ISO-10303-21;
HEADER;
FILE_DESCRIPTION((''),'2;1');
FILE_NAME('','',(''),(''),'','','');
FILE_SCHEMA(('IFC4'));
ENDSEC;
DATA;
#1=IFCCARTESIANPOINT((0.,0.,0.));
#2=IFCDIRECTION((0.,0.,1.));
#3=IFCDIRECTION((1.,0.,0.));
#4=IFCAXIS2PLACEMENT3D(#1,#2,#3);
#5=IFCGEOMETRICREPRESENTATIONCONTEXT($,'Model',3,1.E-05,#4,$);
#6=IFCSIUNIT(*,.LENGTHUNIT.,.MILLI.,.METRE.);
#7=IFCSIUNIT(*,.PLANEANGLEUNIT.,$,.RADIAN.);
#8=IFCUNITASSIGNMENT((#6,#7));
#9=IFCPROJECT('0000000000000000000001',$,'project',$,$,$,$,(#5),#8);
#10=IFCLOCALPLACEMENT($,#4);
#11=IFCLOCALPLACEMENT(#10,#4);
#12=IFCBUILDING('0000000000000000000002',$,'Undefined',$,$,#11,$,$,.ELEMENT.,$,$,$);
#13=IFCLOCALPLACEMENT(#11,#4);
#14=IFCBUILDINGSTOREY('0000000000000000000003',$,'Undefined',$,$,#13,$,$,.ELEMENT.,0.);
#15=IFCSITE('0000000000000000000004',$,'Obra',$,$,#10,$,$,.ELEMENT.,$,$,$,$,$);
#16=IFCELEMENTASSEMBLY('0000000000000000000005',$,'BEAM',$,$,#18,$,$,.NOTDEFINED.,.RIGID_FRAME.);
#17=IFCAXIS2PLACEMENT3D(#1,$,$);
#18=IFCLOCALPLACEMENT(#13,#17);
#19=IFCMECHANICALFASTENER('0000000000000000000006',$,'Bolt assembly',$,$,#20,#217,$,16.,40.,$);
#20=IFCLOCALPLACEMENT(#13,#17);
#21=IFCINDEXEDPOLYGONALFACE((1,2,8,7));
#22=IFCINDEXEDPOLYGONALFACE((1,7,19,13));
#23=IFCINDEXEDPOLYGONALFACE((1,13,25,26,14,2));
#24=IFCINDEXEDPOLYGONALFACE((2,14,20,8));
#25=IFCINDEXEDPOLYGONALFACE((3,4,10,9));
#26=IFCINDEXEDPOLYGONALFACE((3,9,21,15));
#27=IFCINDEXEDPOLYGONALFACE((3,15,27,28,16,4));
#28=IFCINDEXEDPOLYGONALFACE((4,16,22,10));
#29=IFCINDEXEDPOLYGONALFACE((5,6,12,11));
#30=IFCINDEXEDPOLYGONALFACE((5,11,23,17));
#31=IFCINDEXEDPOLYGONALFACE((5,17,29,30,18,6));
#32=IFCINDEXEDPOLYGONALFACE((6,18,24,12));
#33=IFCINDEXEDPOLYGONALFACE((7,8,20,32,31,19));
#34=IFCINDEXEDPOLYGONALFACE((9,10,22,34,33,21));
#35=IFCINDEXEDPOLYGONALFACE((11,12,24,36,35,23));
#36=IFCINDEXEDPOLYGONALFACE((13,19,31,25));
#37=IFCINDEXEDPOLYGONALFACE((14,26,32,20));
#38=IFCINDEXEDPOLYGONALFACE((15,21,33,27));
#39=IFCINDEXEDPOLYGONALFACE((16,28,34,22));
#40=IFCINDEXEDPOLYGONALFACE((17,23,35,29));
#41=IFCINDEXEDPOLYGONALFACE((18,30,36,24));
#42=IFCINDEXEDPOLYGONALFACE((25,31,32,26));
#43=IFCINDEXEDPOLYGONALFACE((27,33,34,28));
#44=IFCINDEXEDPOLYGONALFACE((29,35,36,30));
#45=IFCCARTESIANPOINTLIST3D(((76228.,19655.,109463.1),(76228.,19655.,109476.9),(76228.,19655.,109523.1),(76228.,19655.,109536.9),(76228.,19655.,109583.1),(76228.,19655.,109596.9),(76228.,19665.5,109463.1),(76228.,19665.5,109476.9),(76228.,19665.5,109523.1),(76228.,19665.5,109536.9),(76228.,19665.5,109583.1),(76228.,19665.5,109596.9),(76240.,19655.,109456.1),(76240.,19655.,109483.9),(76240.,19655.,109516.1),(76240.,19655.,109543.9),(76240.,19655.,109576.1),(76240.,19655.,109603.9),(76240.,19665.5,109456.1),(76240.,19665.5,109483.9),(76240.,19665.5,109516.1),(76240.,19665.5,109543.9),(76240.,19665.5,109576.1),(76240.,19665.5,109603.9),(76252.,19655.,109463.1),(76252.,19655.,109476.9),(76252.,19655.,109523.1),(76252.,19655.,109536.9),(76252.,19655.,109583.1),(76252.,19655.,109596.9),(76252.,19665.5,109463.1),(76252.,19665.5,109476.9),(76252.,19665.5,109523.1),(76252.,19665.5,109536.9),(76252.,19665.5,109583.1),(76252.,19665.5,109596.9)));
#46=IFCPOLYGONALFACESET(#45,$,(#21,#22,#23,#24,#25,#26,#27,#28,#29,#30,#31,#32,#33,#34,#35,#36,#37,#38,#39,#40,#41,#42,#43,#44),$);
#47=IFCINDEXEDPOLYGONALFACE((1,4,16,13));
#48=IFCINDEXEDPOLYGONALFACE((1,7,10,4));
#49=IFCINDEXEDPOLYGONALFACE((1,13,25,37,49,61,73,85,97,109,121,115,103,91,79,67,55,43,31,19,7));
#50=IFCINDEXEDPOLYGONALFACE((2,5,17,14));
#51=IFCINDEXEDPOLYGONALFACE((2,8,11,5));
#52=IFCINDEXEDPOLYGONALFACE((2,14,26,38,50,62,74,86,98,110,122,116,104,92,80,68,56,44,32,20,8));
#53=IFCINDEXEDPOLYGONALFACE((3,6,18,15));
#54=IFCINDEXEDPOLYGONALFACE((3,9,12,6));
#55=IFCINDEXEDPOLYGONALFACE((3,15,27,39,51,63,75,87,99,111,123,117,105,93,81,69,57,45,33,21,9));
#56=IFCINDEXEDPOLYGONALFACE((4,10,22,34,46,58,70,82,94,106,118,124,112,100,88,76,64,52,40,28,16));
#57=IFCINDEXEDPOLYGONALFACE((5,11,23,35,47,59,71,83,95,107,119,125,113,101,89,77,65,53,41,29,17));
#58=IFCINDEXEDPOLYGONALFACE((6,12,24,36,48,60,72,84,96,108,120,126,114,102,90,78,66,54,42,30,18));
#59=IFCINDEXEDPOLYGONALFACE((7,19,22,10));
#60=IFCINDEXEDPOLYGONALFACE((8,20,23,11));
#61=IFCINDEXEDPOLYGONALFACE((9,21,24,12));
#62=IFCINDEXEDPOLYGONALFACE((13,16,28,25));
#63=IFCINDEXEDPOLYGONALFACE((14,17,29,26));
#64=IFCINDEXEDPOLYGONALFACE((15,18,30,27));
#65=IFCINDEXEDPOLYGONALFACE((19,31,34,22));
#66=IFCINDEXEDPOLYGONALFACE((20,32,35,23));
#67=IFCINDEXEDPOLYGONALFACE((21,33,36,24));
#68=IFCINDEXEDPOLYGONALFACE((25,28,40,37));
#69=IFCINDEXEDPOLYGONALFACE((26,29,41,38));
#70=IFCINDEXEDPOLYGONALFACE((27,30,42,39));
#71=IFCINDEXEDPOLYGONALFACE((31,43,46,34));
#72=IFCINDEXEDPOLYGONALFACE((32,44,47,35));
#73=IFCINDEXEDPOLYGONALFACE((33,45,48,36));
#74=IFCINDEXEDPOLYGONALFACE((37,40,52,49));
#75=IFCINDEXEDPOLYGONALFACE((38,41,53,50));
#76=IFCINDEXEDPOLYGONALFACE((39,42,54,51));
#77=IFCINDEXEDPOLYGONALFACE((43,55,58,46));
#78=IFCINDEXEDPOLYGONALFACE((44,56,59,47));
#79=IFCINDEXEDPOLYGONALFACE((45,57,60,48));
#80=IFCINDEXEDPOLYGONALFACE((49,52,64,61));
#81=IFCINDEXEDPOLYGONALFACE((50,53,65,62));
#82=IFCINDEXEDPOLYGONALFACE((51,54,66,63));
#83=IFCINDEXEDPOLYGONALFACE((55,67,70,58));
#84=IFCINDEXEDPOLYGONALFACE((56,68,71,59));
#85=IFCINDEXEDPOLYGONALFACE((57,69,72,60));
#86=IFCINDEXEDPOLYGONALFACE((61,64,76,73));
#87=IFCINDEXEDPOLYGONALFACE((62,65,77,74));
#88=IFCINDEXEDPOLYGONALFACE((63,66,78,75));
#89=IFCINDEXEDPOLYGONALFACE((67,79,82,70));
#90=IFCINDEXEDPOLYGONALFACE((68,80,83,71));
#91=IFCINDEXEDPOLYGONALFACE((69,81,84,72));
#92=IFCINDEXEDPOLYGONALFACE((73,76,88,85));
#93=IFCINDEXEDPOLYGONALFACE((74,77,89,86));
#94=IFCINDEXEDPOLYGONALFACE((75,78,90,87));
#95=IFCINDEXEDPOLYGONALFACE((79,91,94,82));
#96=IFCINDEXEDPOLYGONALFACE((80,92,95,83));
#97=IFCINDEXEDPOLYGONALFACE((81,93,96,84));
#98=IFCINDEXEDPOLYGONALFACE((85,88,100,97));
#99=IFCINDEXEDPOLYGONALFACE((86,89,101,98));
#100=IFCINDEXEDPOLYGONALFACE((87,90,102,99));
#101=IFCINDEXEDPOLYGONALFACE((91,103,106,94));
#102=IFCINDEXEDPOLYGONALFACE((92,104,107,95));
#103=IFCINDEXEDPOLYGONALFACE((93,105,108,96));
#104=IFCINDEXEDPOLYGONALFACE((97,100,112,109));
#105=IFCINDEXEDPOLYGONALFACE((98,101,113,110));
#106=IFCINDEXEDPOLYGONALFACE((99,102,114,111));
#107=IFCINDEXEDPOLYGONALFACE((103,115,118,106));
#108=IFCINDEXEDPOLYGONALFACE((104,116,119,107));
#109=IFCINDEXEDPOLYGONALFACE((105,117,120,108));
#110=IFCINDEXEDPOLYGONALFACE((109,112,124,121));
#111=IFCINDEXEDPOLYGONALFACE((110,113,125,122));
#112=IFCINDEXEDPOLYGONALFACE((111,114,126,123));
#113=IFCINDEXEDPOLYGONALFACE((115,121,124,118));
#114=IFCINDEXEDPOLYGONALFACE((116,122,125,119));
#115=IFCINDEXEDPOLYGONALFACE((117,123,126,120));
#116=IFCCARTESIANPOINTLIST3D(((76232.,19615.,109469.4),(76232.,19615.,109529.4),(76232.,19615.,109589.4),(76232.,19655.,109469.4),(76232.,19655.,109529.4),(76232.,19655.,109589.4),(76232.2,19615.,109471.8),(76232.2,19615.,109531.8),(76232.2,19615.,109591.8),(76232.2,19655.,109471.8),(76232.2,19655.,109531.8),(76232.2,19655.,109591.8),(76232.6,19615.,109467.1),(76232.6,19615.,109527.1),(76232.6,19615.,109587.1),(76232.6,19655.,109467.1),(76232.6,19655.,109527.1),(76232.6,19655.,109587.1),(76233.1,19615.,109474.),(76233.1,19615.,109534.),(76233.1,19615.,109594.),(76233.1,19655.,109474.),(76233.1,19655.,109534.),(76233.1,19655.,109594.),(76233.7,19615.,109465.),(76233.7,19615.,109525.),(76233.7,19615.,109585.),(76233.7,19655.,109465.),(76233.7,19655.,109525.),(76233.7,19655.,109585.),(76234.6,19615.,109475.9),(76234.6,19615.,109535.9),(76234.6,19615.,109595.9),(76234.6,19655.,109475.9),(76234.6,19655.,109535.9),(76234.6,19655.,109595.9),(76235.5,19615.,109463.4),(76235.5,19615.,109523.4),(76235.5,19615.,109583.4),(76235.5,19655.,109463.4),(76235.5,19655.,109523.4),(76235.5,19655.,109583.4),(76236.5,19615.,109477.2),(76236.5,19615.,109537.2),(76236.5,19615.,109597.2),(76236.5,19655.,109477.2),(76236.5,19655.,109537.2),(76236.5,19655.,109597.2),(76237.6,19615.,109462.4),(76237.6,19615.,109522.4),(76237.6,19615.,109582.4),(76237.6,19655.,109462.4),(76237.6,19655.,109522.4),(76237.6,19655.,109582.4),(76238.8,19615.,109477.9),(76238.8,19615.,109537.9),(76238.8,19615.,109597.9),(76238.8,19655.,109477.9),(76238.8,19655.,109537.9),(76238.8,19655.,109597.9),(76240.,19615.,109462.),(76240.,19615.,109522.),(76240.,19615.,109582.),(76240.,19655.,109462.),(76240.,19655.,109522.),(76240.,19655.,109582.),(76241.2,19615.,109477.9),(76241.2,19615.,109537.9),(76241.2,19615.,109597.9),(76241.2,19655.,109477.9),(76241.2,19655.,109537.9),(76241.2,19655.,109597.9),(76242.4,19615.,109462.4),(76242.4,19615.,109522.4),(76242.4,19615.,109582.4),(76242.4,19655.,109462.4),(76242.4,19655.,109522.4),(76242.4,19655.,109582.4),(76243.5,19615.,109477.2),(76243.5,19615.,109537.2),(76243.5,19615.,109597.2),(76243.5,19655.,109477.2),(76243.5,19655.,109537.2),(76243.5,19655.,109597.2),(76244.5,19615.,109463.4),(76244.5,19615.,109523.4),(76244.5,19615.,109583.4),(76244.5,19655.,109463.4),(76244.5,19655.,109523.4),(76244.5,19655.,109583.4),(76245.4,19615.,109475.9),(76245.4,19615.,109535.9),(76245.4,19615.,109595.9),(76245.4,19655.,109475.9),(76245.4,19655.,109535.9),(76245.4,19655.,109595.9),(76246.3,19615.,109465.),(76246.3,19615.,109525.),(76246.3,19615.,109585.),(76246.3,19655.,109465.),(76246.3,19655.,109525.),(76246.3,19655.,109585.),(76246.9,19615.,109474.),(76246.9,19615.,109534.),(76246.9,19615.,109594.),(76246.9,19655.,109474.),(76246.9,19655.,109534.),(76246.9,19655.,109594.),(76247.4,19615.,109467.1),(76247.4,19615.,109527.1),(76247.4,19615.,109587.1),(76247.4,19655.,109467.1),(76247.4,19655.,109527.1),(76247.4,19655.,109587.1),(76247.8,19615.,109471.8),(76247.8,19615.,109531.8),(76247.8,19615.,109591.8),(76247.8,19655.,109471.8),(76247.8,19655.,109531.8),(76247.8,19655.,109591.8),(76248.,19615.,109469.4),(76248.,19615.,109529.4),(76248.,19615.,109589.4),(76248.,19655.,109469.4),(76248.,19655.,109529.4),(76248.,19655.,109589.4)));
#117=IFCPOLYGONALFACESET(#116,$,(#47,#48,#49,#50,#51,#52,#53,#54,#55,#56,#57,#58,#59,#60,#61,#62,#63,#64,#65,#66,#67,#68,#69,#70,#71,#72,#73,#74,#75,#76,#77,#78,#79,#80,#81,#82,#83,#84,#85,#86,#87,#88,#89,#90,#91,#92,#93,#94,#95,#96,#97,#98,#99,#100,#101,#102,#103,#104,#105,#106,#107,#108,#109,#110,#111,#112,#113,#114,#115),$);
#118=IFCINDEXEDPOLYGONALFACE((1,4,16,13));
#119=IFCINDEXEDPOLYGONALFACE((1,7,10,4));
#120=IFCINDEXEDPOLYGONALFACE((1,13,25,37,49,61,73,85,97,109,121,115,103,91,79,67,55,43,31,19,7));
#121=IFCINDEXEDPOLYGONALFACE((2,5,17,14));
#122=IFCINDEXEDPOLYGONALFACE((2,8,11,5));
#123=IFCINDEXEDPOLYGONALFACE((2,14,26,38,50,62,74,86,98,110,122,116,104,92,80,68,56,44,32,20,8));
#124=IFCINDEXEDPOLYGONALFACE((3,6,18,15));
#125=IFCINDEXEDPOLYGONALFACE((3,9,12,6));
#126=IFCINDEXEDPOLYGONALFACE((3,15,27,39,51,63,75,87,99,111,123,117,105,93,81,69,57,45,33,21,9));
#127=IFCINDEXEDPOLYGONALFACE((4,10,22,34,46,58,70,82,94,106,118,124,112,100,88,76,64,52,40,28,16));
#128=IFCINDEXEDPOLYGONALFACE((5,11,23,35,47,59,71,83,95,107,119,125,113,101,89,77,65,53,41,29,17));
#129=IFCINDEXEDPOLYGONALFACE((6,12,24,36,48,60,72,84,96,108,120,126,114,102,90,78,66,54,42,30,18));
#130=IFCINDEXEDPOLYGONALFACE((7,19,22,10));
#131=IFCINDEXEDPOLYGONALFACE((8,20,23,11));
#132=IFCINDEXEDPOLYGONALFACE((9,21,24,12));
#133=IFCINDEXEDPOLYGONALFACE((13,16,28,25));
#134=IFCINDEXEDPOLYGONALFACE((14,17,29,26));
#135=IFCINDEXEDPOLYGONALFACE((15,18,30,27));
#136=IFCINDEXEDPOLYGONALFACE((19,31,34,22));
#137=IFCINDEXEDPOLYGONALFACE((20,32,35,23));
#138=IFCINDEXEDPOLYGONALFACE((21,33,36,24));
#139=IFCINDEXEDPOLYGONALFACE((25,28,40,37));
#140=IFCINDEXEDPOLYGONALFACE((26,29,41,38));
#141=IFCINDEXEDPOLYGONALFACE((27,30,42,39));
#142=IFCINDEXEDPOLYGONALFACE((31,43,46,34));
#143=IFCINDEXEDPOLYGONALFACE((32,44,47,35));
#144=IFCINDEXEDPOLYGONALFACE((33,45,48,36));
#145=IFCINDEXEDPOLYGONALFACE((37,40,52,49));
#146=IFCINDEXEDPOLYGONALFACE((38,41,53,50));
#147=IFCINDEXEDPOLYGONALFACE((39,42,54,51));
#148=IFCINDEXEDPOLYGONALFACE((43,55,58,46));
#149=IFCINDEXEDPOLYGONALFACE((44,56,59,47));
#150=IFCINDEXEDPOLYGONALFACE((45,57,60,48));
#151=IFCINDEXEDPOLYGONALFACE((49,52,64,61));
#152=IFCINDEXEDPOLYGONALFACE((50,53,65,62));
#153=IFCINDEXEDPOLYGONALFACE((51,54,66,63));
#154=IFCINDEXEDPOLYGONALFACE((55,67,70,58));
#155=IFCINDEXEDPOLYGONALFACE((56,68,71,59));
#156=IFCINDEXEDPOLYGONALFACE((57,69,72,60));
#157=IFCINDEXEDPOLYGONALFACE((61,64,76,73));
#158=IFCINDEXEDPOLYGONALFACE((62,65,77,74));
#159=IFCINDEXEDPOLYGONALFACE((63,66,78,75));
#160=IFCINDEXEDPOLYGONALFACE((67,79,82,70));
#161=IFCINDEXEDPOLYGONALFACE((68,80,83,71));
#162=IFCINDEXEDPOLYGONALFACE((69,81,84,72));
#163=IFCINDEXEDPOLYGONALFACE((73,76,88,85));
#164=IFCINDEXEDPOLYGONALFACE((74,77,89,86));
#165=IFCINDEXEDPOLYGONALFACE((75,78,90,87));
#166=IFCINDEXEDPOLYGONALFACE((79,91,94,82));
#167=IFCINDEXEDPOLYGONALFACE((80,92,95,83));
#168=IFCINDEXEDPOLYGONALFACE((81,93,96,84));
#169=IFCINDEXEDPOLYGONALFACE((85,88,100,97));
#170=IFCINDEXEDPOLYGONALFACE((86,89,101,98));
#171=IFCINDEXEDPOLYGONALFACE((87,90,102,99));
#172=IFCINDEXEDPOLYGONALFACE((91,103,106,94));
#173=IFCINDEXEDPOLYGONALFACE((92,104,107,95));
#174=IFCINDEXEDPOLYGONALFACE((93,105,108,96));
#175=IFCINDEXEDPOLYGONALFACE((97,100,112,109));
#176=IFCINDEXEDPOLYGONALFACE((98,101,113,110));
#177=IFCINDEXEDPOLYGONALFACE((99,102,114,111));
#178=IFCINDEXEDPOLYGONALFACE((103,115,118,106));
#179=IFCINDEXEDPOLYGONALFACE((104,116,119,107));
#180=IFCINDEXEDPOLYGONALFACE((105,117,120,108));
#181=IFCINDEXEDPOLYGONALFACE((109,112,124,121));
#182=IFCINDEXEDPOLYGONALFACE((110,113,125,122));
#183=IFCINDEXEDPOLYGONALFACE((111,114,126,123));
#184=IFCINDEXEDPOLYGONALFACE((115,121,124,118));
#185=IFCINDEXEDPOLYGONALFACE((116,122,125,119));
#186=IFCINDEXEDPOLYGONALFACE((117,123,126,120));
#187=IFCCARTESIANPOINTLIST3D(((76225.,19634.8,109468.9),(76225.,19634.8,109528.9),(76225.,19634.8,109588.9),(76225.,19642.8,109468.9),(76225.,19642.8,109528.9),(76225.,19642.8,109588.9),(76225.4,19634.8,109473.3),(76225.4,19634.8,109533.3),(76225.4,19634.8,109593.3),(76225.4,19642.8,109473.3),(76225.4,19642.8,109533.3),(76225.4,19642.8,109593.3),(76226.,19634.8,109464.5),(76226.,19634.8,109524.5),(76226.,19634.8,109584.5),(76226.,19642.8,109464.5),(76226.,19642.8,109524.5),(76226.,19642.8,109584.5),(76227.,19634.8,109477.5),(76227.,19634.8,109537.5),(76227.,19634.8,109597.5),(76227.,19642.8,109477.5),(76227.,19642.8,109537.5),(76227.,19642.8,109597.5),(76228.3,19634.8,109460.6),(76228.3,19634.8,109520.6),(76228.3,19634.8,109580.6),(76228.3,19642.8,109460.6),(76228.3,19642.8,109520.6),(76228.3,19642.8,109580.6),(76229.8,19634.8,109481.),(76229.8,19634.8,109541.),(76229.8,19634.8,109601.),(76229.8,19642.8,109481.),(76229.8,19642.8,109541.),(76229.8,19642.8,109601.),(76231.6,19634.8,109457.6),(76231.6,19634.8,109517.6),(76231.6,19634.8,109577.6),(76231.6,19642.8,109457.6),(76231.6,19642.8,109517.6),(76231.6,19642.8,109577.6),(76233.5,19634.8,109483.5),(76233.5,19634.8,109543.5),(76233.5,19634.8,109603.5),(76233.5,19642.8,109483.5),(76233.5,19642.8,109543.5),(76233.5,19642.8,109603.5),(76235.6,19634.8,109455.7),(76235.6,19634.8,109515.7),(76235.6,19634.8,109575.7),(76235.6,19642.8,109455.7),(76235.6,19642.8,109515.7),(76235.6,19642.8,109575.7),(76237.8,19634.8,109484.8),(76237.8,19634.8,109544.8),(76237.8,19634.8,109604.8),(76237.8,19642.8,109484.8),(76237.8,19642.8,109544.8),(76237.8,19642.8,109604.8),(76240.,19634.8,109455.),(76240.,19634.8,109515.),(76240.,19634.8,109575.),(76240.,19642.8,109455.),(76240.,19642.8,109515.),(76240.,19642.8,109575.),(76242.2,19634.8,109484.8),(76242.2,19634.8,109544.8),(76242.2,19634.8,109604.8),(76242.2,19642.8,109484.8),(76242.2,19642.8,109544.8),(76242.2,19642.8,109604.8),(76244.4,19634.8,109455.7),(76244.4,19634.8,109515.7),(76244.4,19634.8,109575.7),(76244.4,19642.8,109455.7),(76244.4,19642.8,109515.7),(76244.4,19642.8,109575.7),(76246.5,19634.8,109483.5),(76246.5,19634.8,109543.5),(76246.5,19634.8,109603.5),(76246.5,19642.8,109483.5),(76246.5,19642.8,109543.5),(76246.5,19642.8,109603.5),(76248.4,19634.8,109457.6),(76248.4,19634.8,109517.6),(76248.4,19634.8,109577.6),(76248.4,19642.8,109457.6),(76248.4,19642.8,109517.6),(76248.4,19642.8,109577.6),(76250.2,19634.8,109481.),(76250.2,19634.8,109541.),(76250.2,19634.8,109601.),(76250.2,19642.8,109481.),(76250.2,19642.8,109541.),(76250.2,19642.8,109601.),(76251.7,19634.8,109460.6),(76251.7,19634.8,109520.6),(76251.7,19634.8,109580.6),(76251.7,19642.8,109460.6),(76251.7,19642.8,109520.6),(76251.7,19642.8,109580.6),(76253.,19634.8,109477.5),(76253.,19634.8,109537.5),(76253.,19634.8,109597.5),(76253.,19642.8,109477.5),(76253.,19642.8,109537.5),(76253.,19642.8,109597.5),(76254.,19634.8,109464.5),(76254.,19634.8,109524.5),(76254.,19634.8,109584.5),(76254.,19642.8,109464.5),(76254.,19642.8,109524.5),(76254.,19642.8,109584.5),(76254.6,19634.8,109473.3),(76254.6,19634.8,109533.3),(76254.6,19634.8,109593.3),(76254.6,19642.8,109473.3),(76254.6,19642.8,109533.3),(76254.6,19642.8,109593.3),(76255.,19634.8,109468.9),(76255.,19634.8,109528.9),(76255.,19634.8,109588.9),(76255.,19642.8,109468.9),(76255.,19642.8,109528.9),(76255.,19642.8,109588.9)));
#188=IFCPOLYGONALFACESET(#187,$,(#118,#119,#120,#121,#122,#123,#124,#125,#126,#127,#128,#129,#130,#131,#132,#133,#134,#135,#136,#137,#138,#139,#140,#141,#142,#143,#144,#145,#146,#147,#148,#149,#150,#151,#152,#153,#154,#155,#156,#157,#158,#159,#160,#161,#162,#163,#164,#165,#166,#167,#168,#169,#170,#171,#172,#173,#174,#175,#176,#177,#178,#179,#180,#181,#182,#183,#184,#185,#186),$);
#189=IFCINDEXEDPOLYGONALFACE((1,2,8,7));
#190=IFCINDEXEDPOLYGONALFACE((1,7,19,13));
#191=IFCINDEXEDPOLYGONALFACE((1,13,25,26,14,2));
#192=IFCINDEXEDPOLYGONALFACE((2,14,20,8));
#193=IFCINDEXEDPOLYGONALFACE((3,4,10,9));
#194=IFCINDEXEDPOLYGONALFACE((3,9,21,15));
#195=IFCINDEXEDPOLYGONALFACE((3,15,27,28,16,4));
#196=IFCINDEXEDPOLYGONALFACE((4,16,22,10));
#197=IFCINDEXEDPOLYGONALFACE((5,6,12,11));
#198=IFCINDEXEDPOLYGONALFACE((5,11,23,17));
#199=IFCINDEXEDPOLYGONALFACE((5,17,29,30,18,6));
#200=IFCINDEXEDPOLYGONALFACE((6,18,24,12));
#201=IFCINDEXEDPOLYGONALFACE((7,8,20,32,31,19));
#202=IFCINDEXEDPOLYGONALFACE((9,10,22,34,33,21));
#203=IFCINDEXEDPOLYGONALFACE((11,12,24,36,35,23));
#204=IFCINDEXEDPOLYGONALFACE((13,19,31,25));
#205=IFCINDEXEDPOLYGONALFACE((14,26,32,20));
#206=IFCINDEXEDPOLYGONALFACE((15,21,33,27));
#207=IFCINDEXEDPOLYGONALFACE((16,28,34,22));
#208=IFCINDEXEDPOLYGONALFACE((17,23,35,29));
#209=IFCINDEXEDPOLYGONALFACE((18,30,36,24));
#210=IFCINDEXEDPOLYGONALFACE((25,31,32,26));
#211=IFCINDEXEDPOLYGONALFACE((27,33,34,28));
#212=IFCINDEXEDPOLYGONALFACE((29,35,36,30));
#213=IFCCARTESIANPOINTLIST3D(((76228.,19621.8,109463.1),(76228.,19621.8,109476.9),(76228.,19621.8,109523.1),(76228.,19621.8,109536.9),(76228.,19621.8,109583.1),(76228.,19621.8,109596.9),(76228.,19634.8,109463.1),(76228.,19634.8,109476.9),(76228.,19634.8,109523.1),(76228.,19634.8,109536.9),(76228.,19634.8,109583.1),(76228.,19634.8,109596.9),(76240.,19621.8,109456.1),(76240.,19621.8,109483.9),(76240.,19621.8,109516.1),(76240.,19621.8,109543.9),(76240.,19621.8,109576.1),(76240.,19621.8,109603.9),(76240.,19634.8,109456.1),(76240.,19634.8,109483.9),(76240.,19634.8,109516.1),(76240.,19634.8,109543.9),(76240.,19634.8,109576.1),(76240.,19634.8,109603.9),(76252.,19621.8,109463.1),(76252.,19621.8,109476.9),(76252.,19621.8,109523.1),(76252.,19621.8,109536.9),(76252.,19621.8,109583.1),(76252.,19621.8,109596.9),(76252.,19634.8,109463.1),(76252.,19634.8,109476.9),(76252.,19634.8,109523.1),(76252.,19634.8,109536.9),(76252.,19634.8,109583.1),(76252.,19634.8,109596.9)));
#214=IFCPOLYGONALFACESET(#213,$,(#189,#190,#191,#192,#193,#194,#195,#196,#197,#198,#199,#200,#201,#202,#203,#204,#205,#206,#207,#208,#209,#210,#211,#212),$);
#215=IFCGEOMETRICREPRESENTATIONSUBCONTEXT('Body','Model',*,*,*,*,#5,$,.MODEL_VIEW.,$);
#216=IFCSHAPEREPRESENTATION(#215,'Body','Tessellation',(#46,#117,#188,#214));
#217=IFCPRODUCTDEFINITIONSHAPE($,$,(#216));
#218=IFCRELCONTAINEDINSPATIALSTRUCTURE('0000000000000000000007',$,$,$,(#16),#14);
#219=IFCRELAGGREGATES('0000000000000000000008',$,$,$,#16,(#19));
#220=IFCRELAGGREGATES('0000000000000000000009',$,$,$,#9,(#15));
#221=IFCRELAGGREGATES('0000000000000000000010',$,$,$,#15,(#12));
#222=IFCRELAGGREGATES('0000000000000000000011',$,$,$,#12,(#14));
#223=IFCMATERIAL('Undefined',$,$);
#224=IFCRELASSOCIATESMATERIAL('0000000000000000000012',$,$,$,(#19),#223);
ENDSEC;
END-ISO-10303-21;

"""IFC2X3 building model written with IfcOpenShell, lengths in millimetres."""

from ifc_helpers import new_model, si_unit, frame, origin_with_axes, origin_2d_with_axis, place, context, subcontext, project, spatial, polyline, circle, outline, extrude, source, transform, mapped, material, element, aggregate, save


model = new_model("IFC2X3")

# Units and contexts
model_context = context("Model", 3, precision=1e-05, world=origin_with_axes())
body_context = subcontext(model_context, "Body", "Model", "MODEL_VIEW")
ifc_project = project(units=[si_unit("LENGTHUNIT", "METRE", prefix="MILLI"), si_unit("PLANEANGLEUNIT", "RADIAN")], contexts=[model_context])

# Site, building, storey
site_placement = place(None, origin_with_axes())
site = spatial("IfcSite", under=ifc_project, at=site_placement, Name="Obra", CompositionType="ELEMENT")
building_placement = place(site_placement, origin_with_axes())
building = spatial("IfcBuilding", under=site, at=building_placement, Name="Undefined", CompositionType="ELEMENT")
storey_placement = place(building_placement, origin_with_axes())
storey = spatial("IfcBuildingStorey", under=building, at=storey_placement, Name="Undefined", CompositionType="ELEMENT", Elevation=0.0)

# Element assembly
assembly_1_placement = place(storey_placement, origin_with_axes())
assembly_1 = element("IfcElementAssembly", 1, at=assembly_1_placement, inside=storey, Name="BEAM", AssemblyPlace="NOTDEFINED", PredefinedType="RIGID_FRAME")

# Mechanical fastener
ifc_material_1 = material(Name="Undefined")
shared_shape_1 = source(origin_with_axes(), body_context, "Body", "SweptSolid", [
    extrude(outline(polyline([(13.9, 0.0), (6.9, 12.0), (-6.9, 12.0), (-13.9, 0.0), (-6.9, -12.0), (6.9, -12.0), (13.9, 0.0)])), frame((0.0, -19.7, 0.0), z_axis=(0.0, 1.0, 0.0), x_axis=(1.0, 0.0, 0.0)), (0.0, 0.0, 1.0), 10.6),
    extrude(circle(Radius=8.0, at=origin_2d_with_axis()), frame((0.0, -9.1, 0.0), z_axis=(0.0, 1.0, 0.0), x_axis=(1.0, 0.0, 0.0)), (0.0, 0.0, 1.0), 40.0),
    extrude(circle(Radius=15.0, at=origin_2d_with_axis()), frame((0.0, 3.1, 0.0), z_axis=(0.0, 1.0, 0.0), x_axis=(1.0, 0.0, 0.0)), (0.0, 0.0, 1.0), 8.0),
    extrude(outline(polyline([(13.9, 0.0), (6.9, 12.0), (-6.9, 12.0), (-13.9, 0.0), (-6.9, -12.0), (6.9, -12.0), (13.9, 0.0)])), frame((0.0, 11.1, 0.0), z_axis=(0.0, 1.0, 0.0), x_axis=(1.0, 0.0, 0.0)), (0.0, 0.0, 1.0), 13.0),
])
mechanical_fastener_1_placement = place(assembly_1_placement, frame((76290.0, 19645.9, 109650.0), z_axis=(-1.0, 0.0, 0.0), x_axis=(0.0, 0.0, -1.0)))
mechanical_fastener_1 = element("IfcMechanicalFastener", 2, at=mechanical_fastener_1_placement, material=ifc_material_1, Name="Bolt assembly", NominalDiameter=16.0, NominalLength=40.0, context=body_context, shape_type="MappedRepresentation", body=[
    mapped(shared_shape_1, transform((60.0, 0.0, 50.0))),
    mapped(shared_shape_1, transform((120.0, 0.0, 50.0))),
    mapped(shared_shape_1, transform((180.0, 0.0, 50.0))),
])
aggregate(assembly_1, [mechanical_fastener_1])

save(model, "model.ifc")
